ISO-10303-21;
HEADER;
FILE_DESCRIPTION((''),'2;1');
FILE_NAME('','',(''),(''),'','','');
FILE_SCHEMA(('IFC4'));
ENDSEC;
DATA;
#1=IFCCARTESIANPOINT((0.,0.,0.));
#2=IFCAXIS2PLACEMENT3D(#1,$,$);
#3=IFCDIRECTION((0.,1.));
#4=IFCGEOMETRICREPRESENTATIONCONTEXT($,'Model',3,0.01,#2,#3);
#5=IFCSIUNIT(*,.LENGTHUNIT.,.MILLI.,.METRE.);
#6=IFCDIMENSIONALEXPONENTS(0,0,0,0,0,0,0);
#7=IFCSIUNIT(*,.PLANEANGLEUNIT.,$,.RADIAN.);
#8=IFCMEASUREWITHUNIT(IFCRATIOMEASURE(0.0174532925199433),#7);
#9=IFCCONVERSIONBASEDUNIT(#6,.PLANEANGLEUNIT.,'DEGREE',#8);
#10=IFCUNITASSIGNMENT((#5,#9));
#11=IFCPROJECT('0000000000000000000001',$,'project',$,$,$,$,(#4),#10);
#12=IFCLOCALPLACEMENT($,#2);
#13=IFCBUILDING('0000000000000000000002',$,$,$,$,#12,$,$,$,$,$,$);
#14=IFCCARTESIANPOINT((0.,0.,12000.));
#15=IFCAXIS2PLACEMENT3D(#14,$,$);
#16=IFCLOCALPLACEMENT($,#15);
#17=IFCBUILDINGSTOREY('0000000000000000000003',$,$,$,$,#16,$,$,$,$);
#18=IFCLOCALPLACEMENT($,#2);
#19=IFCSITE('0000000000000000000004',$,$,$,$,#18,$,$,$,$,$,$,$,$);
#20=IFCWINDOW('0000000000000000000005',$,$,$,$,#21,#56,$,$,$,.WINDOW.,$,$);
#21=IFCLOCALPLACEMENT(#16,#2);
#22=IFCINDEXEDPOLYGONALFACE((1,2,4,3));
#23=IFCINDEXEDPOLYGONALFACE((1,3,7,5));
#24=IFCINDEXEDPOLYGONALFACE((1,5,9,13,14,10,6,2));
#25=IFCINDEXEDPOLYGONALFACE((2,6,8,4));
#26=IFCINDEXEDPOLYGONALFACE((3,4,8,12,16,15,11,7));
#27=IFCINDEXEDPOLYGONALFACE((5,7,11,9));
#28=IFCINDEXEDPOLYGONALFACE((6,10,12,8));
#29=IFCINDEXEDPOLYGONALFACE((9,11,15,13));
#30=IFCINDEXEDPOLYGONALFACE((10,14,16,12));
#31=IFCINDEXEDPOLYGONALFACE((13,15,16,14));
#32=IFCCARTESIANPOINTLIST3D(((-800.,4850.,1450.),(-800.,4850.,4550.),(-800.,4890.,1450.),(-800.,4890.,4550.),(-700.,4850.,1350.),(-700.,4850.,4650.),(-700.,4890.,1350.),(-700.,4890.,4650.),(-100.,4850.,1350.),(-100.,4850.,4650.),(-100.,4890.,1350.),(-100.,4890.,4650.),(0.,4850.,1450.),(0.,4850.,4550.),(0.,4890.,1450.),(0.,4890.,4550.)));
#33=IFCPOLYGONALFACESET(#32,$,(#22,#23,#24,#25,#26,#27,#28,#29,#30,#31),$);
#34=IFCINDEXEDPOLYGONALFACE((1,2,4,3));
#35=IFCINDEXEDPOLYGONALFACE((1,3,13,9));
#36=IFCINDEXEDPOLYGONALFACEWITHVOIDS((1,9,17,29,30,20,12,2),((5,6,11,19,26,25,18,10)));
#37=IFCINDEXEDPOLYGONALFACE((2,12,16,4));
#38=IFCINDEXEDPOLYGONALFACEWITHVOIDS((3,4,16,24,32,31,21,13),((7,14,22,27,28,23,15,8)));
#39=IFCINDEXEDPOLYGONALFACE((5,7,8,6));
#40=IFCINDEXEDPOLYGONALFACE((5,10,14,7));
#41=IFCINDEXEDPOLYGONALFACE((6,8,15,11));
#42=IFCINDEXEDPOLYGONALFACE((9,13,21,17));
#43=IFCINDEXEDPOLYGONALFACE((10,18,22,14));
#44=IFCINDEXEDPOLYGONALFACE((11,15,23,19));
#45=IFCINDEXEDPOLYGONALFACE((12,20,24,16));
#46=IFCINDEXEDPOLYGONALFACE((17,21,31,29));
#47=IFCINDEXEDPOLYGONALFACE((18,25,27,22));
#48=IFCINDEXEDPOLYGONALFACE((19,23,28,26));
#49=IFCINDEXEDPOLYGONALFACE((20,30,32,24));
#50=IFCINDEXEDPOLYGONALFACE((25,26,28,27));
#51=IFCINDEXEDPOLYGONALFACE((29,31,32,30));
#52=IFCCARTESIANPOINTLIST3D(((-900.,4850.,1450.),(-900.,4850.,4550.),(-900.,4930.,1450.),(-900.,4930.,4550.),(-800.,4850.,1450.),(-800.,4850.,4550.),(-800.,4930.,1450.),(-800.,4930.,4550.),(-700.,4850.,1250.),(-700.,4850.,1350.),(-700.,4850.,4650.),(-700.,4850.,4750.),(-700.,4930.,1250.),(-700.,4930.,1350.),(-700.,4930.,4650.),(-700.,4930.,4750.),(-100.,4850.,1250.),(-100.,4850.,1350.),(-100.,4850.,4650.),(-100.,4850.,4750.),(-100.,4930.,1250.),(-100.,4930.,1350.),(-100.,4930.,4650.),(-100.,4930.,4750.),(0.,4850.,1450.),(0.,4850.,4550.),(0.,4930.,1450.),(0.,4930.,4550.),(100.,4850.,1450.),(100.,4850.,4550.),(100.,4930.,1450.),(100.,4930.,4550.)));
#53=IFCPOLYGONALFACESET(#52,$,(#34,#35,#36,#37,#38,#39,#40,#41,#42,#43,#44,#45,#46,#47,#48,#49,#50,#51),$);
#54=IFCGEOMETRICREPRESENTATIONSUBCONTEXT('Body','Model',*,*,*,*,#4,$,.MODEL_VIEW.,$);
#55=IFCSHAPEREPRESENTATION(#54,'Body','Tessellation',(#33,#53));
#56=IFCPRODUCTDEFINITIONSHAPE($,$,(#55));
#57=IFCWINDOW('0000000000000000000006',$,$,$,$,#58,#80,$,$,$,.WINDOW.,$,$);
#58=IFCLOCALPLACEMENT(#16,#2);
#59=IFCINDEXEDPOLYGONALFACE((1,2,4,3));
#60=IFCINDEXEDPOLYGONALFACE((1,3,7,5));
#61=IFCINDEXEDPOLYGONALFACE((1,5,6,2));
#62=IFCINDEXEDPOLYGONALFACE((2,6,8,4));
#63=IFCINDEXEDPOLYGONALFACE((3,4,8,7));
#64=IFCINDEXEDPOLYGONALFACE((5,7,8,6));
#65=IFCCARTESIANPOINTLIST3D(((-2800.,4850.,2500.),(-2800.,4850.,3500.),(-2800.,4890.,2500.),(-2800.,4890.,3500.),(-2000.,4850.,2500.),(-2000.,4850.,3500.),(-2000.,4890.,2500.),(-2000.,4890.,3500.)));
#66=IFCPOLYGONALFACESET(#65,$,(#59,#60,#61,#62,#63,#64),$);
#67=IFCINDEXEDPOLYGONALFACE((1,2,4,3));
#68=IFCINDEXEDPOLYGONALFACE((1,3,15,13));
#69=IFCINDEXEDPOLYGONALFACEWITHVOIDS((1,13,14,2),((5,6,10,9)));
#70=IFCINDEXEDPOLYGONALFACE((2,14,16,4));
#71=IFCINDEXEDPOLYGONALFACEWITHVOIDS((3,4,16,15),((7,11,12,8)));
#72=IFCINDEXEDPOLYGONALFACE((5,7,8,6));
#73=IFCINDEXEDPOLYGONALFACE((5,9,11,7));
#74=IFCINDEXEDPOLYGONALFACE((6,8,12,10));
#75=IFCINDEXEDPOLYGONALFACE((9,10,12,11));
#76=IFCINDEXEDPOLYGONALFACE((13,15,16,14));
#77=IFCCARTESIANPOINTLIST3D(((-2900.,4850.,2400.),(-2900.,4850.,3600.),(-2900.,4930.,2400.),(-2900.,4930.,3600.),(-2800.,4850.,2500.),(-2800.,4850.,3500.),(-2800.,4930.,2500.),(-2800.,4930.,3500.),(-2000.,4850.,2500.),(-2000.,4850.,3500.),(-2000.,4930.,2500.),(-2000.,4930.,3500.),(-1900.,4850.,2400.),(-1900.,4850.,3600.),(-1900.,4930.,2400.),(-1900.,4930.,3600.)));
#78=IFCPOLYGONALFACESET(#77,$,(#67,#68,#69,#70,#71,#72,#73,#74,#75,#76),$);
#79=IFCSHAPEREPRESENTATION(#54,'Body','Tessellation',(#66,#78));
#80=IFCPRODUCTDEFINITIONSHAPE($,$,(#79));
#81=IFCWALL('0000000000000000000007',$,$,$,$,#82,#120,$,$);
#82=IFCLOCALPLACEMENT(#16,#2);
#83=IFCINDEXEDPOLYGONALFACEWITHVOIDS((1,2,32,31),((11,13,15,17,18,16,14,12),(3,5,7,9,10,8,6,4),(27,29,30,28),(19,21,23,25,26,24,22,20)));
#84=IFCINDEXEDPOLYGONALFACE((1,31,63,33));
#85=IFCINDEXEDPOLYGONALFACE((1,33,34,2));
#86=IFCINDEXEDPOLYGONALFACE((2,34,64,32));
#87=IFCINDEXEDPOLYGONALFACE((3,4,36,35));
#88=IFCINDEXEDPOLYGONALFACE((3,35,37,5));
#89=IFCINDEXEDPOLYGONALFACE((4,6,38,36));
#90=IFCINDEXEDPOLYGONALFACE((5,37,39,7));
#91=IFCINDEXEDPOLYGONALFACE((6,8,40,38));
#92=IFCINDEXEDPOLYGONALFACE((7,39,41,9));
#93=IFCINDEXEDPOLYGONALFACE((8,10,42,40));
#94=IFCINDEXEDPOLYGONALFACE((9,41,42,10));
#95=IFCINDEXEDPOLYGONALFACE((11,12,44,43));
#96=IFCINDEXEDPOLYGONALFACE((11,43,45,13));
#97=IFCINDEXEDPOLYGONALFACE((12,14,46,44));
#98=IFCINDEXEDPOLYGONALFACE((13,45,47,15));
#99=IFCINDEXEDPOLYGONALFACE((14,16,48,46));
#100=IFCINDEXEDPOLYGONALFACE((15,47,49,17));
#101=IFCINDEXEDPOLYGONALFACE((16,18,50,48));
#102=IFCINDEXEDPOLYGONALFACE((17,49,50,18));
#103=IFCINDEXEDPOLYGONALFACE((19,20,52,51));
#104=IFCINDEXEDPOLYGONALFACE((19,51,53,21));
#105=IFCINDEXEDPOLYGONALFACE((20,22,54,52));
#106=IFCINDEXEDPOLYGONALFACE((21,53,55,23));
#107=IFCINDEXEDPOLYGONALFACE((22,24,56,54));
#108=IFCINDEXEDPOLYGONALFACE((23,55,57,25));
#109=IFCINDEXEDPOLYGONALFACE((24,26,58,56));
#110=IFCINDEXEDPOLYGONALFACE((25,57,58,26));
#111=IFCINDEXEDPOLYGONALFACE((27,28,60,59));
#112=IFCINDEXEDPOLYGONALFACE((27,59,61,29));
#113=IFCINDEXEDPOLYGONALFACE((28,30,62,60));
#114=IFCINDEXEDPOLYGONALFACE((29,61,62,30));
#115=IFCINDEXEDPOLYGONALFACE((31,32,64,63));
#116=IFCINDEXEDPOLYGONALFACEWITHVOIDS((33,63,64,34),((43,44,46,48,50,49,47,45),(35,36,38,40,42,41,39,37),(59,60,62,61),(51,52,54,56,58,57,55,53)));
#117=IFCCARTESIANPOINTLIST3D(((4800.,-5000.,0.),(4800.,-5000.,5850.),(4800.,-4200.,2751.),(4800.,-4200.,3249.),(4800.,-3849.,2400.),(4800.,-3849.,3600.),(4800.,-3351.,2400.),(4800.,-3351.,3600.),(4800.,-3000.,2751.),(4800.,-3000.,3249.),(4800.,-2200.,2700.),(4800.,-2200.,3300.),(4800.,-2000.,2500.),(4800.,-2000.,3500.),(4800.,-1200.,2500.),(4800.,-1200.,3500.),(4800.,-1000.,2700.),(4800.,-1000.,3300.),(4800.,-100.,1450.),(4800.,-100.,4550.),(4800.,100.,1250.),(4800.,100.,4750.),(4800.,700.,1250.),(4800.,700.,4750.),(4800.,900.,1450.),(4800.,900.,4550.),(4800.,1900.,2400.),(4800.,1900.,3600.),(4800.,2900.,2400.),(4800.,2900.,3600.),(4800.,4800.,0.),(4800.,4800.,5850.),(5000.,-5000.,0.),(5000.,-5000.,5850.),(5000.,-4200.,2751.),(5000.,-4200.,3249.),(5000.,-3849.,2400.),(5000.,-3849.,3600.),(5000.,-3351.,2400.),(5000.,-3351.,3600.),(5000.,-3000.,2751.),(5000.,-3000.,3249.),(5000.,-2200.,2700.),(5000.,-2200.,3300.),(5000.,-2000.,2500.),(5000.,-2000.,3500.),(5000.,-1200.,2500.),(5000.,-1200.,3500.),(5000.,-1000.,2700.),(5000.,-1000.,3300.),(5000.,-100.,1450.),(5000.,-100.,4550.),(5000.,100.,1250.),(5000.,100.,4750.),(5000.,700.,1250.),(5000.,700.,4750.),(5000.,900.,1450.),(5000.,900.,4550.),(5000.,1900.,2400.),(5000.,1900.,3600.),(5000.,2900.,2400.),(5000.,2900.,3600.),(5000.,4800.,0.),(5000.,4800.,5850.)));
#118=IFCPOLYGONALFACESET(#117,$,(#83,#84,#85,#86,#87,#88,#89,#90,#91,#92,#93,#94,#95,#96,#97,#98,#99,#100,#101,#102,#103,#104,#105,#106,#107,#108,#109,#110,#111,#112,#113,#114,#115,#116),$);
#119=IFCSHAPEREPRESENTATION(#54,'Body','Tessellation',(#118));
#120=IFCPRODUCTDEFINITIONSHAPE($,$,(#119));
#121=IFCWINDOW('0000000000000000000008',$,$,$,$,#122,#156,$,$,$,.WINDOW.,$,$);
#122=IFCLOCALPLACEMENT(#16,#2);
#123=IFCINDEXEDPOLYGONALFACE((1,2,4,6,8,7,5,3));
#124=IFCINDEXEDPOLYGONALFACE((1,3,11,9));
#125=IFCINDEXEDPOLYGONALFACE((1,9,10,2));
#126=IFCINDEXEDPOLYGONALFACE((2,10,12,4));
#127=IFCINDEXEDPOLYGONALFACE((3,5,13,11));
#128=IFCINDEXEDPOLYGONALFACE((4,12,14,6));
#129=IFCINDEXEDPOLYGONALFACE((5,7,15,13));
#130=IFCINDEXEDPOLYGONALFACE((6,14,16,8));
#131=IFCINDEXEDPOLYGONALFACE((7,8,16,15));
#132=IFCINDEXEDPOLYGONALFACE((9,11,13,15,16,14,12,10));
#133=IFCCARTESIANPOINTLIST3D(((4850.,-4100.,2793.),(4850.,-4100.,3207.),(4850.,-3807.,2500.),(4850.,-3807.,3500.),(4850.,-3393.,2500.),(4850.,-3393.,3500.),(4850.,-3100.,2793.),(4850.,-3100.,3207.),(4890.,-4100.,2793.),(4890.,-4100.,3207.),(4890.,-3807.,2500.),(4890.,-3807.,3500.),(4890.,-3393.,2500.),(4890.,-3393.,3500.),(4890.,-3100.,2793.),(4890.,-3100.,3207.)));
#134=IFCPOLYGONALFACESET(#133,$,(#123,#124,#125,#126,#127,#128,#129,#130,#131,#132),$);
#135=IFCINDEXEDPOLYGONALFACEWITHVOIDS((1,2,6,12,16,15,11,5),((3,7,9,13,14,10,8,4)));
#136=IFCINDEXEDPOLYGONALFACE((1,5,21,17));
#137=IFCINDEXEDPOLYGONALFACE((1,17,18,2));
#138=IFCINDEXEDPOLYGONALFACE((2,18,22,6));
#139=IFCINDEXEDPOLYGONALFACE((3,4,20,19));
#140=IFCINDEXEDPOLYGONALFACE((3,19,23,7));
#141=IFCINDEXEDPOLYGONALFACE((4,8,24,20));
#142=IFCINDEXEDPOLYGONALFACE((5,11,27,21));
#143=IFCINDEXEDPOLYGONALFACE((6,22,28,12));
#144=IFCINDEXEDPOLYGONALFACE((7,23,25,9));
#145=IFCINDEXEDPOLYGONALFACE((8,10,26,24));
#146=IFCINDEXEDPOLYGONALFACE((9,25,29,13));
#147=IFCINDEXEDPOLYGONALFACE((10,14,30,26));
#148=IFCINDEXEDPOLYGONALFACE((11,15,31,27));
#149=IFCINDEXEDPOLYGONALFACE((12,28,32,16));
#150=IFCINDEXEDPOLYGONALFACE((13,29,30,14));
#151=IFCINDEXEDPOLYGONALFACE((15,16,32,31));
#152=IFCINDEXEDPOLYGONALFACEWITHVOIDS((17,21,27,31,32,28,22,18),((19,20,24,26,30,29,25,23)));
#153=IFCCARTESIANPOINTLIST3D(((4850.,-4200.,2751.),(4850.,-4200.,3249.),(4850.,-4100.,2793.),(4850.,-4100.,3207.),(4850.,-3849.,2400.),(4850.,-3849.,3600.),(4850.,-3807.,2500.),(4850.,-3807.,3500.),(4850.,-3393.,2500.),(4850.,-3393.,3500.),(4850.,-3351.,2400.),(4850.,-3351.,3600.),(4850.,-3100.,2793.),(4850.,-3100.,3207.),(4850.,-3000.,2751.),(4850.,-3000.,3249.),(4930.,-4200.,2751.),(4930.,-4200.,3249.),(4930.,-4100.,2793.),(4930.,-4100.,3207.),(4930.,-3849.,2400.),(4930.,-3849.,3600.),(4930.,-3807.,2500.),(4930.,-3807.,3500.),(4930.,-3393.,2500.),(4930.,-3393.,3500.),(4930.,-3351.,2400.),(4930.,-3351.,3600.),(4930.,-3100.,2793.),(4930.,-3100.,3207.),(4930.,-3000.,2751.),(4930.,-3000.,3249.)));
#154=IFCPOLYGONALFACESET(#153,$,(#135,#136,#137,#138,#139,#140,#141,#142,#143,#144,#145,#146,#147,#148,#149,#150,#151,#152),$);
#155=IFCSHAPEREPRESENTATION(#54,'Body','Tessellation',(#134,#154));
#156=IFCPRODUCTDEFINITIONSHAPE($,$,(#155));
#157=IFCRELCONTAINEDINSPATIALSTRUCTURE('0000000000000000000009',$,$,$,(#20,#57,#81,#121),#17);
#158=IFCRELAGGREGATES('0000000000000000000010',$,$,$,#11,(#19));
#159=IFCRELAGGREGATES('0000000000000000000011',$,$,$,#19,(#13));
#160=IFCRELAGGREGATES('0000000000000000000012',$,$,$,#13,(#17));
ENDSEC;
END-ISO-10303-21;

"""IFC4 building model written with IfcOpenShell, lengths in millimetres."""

from ifc_helpers import new_model, entity, si_unit, converted_unit, direction, frame, origin, origin_2d, place, context, subcontext, project, spatial, polyline, rectangle, outline, extrude, element, save


model = new_model("IFC4")

# Units and contexts
model_context = context("Model", 3, precision=0.01, world=origin(), true_north=direction((0.0, 1.0)))
body_context = subcontext(model_context, "Body", "Model", "MODEL_VIEW")
ifc_project = project(units=[si_unit("LENGTHUNIT", "METRE", prefix="MILLI"), converted_unit("PLANEANGLEUNIT", "DEGREE", entity("IfcRatioMeasure", 0.0174532925199433), si_unit("PLANEANGLEUNIT", "RADIAN"), dimensions=[0, 0, 0, 0, 0, 0, 0])], contexts=[model_context])

# Site, building, storey
site_placement = place(None, origin())
site = spatial("IfcSite", under=ifc_project, at=site_placement)
building_placement = place(None, origin())
building = spatial("IfcBuilding", under=site, at=building_placement)
storey_placement = place(None, frame((0.0, 0.0, 12000.0)))
storey = spatial("IfcBuildingStorey", under=building, at=storey_placement)

# Shared definitions
wall_1_placement = place(storey_placement, frame((100.0, 4900.0, 0.0), z_axis=(0.0, 0.0, 1.0), x_axis=(-1.0, 0.0, 0.0)))
window_1_placement = place(wall_1_placement, frame((500.0, 50.0, 3000.0)))
window_2_placement = place(wall_1_placement, frame((2500.0, 50.0, 3000.0)))

# Windows
cartesian_point_1 = entity("IfcCartesianPoint", [-500.0, -207.0])
shared_polyline_1 = entity("IfcPolyline", [cartesian_point_1, entity("IfcCartesianPoint", [-500.0, 207.0]), entity("IfcCartesianPoint", [-207.0, 500.0]), entity("IfcCartesianPoint", [207.0, 500.0]), entity("IfcCartesianPoint", [500.0, 207.0]), entity("IfcCartesianPoint", [500.0, -207.0]), entity("IfcCartesianPoint", [207.0, -500.0]), entity("IfcCartesianPoint", [-207.0, -500.0]), cartesian_point_1])
cartesian_point_2 = entity("IfcCartesianPoint", [-400.0, -1550.0])
shared_polyline_2 = entity("IfcPolyline", [cartesian_point_2, entity("IfcCartesianPoint", [-400.0, 1550.0]), entity("IfcCartesianPoint", [-300.0, 1650.0]), entity("IfcCartesianPoint", [300.0, 1650.0]), entity("IfcCartesianPoint", [400.0, 1550.0]), entity("IfcCartesianPoint", [400.0, -1550.0]), entity("IfcCartesianPoint", [300.0, -1650.0]), entity("IfcCartesianPoint", [-300.0, -1650.0]), cartesian_point_2])
cartesian_point_3 = entity("IfcCartesianPoint", [-500.0, -1550.0])
element("IfcWindow", 1, at=window_1_placement, inside=storey, PredefinedType="WINDOW", context=body_context, shape_type="SweptSolid", body=[
    entity("IfcExtrudedAreaSolid", entity("IfcArbitraryClosedProfileDef", "AREA", None, shared_polyline_2), entity("IfcAxis2Placement3D", entity("IfcCartesianPoint", [0.0, 0.0, 0.0]), entity("IfcDirection", [0.0, -1.0, 0.0]), entity("IfcDirection", [1.0, 0.0, 0.0])), entity("IfcDirection", [0.0, 0.0, 1.0]), 40.0),
    entity("IfcExtrudedAreaSolid", entity("IfcArbitraryProfileDefWithVoids", "AREA", None, entity("IfcPolyline", [cartesian_point_3, entity("IfcCartesianPoint", [-500.0, 1550.0]), entity("IfcCartesianPoint", [-300.0, 1750.0]), entity("IfcCartesianPoint", [300.0, 1750.0]), entity("IfcCartesianPoint", [500.0, 1550.0]), entity("IfcCartesianPoint", [500.0, -1550.0]), entity("IfcCartesianPoint", [300.0, -1750.0]), entity("IfcCartesianPoint", [-300.0, -1750.0]), cartesian_point_3]), [shared_polyline_2]), entity("IfcAxis2Placement3D", entity("IfcCartesianPoint", [0.0, 0.0, 0.0]), entity("IfcDirection", [0.0, -1.0, 0.0]), entity("IfcDirection", [1.0, 0.0, 0.0])), entity("IfcDirection", [0.0, 0.0, 1.0]), 80.0),
])
cartesian_point_4 = entity("IfcCartesianPoint", [-400.0, -500.0])
shared_polyline_3 = entity("IfcPolyline", [cartesian_point_4, entity("IfcCartesianPoint", [-400.0, 500.0]), entity("IfcCartesianPoint", [-400.0, 500.0]), entity("IfcCartesianPoint", [400.0, 500.0]), entity("IfcCartesianPoint", [400.0, 500.0]), entity("IfcCartesianPoint", [400.0, -500.0]), entity("IfcCartesianPoint", [400.0, -500.0]), entity("IfcCartesianPoint", [-400.0, -500.0]), cartesian_point_4])
cartesian_point_5 = entity("IfcCartesianPoint", [-500.0, -600.0])
element("IfcWindow", 2, at=window_2_placement, inside=storey, PredefinedType="WINDOW", context=body_context, shape_type="SweptSolid", body=[
    entity("IfcExtrudedAreaSolid", entity("IfcArbitraryClosedProfileDef", "AREA", None, shared_polyline_3), entity("IfcAxis2Placement3D", entity("IfcCartesianPoint", [0.0, 0.0, 0.0]), entity("IfcDirection", [0.0, -1.0, 0.0]), entity("IfcDirection", [1.0, 0.0, 0.0])), entity("IfcDirection", [0.0, 0.0, 1.0]), 40.0),
    entity("IfcExtrudedAreaSolid", entity("IfcArbitraryProfileDefWithVoids", "AREA", None, entity("IfcPolyline", [cartesian_point_5, entity("IfcCartesianPoint", [-500.0, 600.0]), entity("IfcCartesianPoint", [-500.0, 600.0]), entity("IfcCartesianPoint", [500.0, 600.0]), entity("IfcCartesianPoint", [500.0, 600.0]), entity("IfcCartesianPoint", [500.0, -600.0]), entity("IfcCartesianPoint", [500.0, -600.0]), entity("IfcCartesianPoint", [-500.0, -600.0]), cartesian_point_5]), [shared_polyline_3]), entity("IfcAxis2Placement3D", entity("IfcCartesianPoint", [0.0, 0.0, 0.0]), entity("IfcDirection", [0.0, -1.0, 0.0]), entity("IfcDirection", [1.0, 0.0, 0.0])), entity("IfcDirection", [0.0, 0.0, 1.0]), 80.0),
])

# Wall, openings
wall_2_placement = place(storey_placement, frame((4900.0, -100.0, 0.0), z_axis=(0.0, 0.0, 1.0), x_axis=(0.0, 1.0, 0.0)))
wall_2 = element("IfcWall", 3, at=wall_2_placement, inside=storey, context=body_context, shape_type="SweptSolid", body=[
    extrude(rectangle(XDim=9800.0, YDim=200.0, at=origin_2d()), origin(), (0.0, 0.0, 1.0), 5850.0),
])
window_3_placement = place(wall_2_placement, frame((-3500.0, 50.0, 3000.0)))
opening_1_placement = place(window_3_placement, frame((0.0, 50.0, 0.0)))
element("IfcOpeningElement", 4, at=opening_1_placement, cuts=wall_2, context=body_context, shape_type="SweptSolid", body=[
    extrude(outline(polyline([(-600.0, -249.0), (-600.0, 249.0), (-249.0, 600.0), (249.0, 600.0), (600.0, 249.0), (600.0, -249.0), (249.0, -600.0), (-249.0, -600.0), (-600.0, -249.0)])), frame((0.0, 0.0, 0.0), z_axis=(0.0, -1.0, 0.0), x_axis=(1.0, 0.0, 0.0)), (0.0, 0.0, 1.0), 200.0),
])
window_4_placement = place(wall_2_placement, frame((-1500.0, 50.0, 3000.0)))
opening_2_placement = place(window_4_placement, frame((0.0, 50.0, 0.0)))
element("IfcOpeningElement", 5, at=opening_2_placement, cuts=wall_2, context=body_context, shape_type="SweptSolid", body=[
    extrude(outline(polyline([(-600.0, -300.0), (-600.0, 300.0), (-400.0, 500.0), (400.0, 500.0), (600.0, 300.0), (600.0, -300.0), (400.0, -500.0), (-400.0, -500.0), (-600.0, -300.0)])), frame((0.0, 0.0, 0.0), z_axis=(0.0, -1.0, 0.0), x_axis=(1.0, 0.0, 0.0)), (0.0, 0.0, 1.0), 200.0),
])
window_5_placement = place(wall_2_placement, frame((500.0, 50.0, 3000.0)))
opening_3_placement = place(window_5_placement, frame((0.0, 50.0, 0.0)))
element("IfcOpeningElement", 6, at=opening_3_placement, cuts=wall_2, context=body_context, shape_type="SweptSolid", body=[
    extrude(outline(polyline([(-500.0, -1550.0), (-500.0, 1550.0), (-300.0, 1750.0), (300.0, 1750.0), (500.0, 1550.0), (500.0, -1550.0), (300.0, -1750.0), (-300.0, -1750.0), (-500.0, -1550.0)])), frame((0.0, 0.0, 0.0), z_axis=(0.0, -1.0, 0.0), x_axis=(1.0, 0.0, 0.0)), (0.0, 0.0, 1.0), 200.0),
])
window_6_placement = place(wall_2_placement, frame((2500.0, 50.0, 3000.0)))
opening_4_placement = place(window_6_placement, frame((0.0, 50.0, 0.0)))
element("IfcOpeningElement", 7, at=opening_4_placement, cuts=wall_2, context=body_context, shape_type="SweptSolid", body=[
    extrude(outline(polyline([(-500.0, -600.0), (-500.0, 600.0), (-500.0, 600.0), (500.0, 600.0), (500.0, 600.0), (500.0, -600.0), (500.0, -600.0), (-500.0, -600.0), (-500.0, -600.0)])), frame((0.0, 0.0, 0.0), z_axis=(0.0, -1.0, 0.0), x_axis=(1.0, 0.0, 0.0)), (0.0, 0.0, 1.0), 200.0),
])

# Window
cartesian_point_6 = entity("IfcCartesianPoint", [-600.0, -249.0])
element("IfcWindow", 8, at=window_3_placement, inside=storey, PredefinedType="WINDOW", context=body_context, shape_type="SweptSolid", body=[
    entity("IfcExtrudedAreaSolid", entity("IfcArbitraryClosedProfileDef", "AREA", None, shared_polyline_1), entity("IfcAxis2Placement3D", entity("IfcCartesianPoint", [0.0, 0.0, 0.0]), entity("IfcDirection", [0.0, -1.0, 0.0]), entity("IfcDirection", [1.0, 0.0, 0.0])), entity("IfcDirection", [0.0, 0.0, 1.0]), 40.0),
    entity("IfcExtrudedAreaSolid", entity("IfcArbitraryProfileDefWithVoids", "AREA", None, entity("IfcPolyline", [cartesian_point_6, entity("IfcCartesianPoint", [-600.0, 249.0]), entity("IfcCartesianPoint", [-249.0, 600.0]), entity("IfcCartesianPoint", [249.0, 600.0]), entity("IfcCartesianPoint", [600.0, 249.0]), entity("IfcCartesianPoint", [600.0, -249.0]), entity("IfcCartesianPoint", [249.0, -600.0]), entity("IfcCartesianPoint", [-249.0, -600.0]), cartesian_point_6]), [shared_polyline_1]), entity("IfcAxis2Placement3D", entity("IfcCartesianPoint", [0.0, 0.0, 0.0]), entity("IfcDirection", [0.0, -1.0, 0.0]), entity("IfcDirection", [1.0, 0.0, 0.0])), entity("IfcDirection", [0.0, 0.0, 1.0]), 80.0),
])

save(model, "model.ifc")
